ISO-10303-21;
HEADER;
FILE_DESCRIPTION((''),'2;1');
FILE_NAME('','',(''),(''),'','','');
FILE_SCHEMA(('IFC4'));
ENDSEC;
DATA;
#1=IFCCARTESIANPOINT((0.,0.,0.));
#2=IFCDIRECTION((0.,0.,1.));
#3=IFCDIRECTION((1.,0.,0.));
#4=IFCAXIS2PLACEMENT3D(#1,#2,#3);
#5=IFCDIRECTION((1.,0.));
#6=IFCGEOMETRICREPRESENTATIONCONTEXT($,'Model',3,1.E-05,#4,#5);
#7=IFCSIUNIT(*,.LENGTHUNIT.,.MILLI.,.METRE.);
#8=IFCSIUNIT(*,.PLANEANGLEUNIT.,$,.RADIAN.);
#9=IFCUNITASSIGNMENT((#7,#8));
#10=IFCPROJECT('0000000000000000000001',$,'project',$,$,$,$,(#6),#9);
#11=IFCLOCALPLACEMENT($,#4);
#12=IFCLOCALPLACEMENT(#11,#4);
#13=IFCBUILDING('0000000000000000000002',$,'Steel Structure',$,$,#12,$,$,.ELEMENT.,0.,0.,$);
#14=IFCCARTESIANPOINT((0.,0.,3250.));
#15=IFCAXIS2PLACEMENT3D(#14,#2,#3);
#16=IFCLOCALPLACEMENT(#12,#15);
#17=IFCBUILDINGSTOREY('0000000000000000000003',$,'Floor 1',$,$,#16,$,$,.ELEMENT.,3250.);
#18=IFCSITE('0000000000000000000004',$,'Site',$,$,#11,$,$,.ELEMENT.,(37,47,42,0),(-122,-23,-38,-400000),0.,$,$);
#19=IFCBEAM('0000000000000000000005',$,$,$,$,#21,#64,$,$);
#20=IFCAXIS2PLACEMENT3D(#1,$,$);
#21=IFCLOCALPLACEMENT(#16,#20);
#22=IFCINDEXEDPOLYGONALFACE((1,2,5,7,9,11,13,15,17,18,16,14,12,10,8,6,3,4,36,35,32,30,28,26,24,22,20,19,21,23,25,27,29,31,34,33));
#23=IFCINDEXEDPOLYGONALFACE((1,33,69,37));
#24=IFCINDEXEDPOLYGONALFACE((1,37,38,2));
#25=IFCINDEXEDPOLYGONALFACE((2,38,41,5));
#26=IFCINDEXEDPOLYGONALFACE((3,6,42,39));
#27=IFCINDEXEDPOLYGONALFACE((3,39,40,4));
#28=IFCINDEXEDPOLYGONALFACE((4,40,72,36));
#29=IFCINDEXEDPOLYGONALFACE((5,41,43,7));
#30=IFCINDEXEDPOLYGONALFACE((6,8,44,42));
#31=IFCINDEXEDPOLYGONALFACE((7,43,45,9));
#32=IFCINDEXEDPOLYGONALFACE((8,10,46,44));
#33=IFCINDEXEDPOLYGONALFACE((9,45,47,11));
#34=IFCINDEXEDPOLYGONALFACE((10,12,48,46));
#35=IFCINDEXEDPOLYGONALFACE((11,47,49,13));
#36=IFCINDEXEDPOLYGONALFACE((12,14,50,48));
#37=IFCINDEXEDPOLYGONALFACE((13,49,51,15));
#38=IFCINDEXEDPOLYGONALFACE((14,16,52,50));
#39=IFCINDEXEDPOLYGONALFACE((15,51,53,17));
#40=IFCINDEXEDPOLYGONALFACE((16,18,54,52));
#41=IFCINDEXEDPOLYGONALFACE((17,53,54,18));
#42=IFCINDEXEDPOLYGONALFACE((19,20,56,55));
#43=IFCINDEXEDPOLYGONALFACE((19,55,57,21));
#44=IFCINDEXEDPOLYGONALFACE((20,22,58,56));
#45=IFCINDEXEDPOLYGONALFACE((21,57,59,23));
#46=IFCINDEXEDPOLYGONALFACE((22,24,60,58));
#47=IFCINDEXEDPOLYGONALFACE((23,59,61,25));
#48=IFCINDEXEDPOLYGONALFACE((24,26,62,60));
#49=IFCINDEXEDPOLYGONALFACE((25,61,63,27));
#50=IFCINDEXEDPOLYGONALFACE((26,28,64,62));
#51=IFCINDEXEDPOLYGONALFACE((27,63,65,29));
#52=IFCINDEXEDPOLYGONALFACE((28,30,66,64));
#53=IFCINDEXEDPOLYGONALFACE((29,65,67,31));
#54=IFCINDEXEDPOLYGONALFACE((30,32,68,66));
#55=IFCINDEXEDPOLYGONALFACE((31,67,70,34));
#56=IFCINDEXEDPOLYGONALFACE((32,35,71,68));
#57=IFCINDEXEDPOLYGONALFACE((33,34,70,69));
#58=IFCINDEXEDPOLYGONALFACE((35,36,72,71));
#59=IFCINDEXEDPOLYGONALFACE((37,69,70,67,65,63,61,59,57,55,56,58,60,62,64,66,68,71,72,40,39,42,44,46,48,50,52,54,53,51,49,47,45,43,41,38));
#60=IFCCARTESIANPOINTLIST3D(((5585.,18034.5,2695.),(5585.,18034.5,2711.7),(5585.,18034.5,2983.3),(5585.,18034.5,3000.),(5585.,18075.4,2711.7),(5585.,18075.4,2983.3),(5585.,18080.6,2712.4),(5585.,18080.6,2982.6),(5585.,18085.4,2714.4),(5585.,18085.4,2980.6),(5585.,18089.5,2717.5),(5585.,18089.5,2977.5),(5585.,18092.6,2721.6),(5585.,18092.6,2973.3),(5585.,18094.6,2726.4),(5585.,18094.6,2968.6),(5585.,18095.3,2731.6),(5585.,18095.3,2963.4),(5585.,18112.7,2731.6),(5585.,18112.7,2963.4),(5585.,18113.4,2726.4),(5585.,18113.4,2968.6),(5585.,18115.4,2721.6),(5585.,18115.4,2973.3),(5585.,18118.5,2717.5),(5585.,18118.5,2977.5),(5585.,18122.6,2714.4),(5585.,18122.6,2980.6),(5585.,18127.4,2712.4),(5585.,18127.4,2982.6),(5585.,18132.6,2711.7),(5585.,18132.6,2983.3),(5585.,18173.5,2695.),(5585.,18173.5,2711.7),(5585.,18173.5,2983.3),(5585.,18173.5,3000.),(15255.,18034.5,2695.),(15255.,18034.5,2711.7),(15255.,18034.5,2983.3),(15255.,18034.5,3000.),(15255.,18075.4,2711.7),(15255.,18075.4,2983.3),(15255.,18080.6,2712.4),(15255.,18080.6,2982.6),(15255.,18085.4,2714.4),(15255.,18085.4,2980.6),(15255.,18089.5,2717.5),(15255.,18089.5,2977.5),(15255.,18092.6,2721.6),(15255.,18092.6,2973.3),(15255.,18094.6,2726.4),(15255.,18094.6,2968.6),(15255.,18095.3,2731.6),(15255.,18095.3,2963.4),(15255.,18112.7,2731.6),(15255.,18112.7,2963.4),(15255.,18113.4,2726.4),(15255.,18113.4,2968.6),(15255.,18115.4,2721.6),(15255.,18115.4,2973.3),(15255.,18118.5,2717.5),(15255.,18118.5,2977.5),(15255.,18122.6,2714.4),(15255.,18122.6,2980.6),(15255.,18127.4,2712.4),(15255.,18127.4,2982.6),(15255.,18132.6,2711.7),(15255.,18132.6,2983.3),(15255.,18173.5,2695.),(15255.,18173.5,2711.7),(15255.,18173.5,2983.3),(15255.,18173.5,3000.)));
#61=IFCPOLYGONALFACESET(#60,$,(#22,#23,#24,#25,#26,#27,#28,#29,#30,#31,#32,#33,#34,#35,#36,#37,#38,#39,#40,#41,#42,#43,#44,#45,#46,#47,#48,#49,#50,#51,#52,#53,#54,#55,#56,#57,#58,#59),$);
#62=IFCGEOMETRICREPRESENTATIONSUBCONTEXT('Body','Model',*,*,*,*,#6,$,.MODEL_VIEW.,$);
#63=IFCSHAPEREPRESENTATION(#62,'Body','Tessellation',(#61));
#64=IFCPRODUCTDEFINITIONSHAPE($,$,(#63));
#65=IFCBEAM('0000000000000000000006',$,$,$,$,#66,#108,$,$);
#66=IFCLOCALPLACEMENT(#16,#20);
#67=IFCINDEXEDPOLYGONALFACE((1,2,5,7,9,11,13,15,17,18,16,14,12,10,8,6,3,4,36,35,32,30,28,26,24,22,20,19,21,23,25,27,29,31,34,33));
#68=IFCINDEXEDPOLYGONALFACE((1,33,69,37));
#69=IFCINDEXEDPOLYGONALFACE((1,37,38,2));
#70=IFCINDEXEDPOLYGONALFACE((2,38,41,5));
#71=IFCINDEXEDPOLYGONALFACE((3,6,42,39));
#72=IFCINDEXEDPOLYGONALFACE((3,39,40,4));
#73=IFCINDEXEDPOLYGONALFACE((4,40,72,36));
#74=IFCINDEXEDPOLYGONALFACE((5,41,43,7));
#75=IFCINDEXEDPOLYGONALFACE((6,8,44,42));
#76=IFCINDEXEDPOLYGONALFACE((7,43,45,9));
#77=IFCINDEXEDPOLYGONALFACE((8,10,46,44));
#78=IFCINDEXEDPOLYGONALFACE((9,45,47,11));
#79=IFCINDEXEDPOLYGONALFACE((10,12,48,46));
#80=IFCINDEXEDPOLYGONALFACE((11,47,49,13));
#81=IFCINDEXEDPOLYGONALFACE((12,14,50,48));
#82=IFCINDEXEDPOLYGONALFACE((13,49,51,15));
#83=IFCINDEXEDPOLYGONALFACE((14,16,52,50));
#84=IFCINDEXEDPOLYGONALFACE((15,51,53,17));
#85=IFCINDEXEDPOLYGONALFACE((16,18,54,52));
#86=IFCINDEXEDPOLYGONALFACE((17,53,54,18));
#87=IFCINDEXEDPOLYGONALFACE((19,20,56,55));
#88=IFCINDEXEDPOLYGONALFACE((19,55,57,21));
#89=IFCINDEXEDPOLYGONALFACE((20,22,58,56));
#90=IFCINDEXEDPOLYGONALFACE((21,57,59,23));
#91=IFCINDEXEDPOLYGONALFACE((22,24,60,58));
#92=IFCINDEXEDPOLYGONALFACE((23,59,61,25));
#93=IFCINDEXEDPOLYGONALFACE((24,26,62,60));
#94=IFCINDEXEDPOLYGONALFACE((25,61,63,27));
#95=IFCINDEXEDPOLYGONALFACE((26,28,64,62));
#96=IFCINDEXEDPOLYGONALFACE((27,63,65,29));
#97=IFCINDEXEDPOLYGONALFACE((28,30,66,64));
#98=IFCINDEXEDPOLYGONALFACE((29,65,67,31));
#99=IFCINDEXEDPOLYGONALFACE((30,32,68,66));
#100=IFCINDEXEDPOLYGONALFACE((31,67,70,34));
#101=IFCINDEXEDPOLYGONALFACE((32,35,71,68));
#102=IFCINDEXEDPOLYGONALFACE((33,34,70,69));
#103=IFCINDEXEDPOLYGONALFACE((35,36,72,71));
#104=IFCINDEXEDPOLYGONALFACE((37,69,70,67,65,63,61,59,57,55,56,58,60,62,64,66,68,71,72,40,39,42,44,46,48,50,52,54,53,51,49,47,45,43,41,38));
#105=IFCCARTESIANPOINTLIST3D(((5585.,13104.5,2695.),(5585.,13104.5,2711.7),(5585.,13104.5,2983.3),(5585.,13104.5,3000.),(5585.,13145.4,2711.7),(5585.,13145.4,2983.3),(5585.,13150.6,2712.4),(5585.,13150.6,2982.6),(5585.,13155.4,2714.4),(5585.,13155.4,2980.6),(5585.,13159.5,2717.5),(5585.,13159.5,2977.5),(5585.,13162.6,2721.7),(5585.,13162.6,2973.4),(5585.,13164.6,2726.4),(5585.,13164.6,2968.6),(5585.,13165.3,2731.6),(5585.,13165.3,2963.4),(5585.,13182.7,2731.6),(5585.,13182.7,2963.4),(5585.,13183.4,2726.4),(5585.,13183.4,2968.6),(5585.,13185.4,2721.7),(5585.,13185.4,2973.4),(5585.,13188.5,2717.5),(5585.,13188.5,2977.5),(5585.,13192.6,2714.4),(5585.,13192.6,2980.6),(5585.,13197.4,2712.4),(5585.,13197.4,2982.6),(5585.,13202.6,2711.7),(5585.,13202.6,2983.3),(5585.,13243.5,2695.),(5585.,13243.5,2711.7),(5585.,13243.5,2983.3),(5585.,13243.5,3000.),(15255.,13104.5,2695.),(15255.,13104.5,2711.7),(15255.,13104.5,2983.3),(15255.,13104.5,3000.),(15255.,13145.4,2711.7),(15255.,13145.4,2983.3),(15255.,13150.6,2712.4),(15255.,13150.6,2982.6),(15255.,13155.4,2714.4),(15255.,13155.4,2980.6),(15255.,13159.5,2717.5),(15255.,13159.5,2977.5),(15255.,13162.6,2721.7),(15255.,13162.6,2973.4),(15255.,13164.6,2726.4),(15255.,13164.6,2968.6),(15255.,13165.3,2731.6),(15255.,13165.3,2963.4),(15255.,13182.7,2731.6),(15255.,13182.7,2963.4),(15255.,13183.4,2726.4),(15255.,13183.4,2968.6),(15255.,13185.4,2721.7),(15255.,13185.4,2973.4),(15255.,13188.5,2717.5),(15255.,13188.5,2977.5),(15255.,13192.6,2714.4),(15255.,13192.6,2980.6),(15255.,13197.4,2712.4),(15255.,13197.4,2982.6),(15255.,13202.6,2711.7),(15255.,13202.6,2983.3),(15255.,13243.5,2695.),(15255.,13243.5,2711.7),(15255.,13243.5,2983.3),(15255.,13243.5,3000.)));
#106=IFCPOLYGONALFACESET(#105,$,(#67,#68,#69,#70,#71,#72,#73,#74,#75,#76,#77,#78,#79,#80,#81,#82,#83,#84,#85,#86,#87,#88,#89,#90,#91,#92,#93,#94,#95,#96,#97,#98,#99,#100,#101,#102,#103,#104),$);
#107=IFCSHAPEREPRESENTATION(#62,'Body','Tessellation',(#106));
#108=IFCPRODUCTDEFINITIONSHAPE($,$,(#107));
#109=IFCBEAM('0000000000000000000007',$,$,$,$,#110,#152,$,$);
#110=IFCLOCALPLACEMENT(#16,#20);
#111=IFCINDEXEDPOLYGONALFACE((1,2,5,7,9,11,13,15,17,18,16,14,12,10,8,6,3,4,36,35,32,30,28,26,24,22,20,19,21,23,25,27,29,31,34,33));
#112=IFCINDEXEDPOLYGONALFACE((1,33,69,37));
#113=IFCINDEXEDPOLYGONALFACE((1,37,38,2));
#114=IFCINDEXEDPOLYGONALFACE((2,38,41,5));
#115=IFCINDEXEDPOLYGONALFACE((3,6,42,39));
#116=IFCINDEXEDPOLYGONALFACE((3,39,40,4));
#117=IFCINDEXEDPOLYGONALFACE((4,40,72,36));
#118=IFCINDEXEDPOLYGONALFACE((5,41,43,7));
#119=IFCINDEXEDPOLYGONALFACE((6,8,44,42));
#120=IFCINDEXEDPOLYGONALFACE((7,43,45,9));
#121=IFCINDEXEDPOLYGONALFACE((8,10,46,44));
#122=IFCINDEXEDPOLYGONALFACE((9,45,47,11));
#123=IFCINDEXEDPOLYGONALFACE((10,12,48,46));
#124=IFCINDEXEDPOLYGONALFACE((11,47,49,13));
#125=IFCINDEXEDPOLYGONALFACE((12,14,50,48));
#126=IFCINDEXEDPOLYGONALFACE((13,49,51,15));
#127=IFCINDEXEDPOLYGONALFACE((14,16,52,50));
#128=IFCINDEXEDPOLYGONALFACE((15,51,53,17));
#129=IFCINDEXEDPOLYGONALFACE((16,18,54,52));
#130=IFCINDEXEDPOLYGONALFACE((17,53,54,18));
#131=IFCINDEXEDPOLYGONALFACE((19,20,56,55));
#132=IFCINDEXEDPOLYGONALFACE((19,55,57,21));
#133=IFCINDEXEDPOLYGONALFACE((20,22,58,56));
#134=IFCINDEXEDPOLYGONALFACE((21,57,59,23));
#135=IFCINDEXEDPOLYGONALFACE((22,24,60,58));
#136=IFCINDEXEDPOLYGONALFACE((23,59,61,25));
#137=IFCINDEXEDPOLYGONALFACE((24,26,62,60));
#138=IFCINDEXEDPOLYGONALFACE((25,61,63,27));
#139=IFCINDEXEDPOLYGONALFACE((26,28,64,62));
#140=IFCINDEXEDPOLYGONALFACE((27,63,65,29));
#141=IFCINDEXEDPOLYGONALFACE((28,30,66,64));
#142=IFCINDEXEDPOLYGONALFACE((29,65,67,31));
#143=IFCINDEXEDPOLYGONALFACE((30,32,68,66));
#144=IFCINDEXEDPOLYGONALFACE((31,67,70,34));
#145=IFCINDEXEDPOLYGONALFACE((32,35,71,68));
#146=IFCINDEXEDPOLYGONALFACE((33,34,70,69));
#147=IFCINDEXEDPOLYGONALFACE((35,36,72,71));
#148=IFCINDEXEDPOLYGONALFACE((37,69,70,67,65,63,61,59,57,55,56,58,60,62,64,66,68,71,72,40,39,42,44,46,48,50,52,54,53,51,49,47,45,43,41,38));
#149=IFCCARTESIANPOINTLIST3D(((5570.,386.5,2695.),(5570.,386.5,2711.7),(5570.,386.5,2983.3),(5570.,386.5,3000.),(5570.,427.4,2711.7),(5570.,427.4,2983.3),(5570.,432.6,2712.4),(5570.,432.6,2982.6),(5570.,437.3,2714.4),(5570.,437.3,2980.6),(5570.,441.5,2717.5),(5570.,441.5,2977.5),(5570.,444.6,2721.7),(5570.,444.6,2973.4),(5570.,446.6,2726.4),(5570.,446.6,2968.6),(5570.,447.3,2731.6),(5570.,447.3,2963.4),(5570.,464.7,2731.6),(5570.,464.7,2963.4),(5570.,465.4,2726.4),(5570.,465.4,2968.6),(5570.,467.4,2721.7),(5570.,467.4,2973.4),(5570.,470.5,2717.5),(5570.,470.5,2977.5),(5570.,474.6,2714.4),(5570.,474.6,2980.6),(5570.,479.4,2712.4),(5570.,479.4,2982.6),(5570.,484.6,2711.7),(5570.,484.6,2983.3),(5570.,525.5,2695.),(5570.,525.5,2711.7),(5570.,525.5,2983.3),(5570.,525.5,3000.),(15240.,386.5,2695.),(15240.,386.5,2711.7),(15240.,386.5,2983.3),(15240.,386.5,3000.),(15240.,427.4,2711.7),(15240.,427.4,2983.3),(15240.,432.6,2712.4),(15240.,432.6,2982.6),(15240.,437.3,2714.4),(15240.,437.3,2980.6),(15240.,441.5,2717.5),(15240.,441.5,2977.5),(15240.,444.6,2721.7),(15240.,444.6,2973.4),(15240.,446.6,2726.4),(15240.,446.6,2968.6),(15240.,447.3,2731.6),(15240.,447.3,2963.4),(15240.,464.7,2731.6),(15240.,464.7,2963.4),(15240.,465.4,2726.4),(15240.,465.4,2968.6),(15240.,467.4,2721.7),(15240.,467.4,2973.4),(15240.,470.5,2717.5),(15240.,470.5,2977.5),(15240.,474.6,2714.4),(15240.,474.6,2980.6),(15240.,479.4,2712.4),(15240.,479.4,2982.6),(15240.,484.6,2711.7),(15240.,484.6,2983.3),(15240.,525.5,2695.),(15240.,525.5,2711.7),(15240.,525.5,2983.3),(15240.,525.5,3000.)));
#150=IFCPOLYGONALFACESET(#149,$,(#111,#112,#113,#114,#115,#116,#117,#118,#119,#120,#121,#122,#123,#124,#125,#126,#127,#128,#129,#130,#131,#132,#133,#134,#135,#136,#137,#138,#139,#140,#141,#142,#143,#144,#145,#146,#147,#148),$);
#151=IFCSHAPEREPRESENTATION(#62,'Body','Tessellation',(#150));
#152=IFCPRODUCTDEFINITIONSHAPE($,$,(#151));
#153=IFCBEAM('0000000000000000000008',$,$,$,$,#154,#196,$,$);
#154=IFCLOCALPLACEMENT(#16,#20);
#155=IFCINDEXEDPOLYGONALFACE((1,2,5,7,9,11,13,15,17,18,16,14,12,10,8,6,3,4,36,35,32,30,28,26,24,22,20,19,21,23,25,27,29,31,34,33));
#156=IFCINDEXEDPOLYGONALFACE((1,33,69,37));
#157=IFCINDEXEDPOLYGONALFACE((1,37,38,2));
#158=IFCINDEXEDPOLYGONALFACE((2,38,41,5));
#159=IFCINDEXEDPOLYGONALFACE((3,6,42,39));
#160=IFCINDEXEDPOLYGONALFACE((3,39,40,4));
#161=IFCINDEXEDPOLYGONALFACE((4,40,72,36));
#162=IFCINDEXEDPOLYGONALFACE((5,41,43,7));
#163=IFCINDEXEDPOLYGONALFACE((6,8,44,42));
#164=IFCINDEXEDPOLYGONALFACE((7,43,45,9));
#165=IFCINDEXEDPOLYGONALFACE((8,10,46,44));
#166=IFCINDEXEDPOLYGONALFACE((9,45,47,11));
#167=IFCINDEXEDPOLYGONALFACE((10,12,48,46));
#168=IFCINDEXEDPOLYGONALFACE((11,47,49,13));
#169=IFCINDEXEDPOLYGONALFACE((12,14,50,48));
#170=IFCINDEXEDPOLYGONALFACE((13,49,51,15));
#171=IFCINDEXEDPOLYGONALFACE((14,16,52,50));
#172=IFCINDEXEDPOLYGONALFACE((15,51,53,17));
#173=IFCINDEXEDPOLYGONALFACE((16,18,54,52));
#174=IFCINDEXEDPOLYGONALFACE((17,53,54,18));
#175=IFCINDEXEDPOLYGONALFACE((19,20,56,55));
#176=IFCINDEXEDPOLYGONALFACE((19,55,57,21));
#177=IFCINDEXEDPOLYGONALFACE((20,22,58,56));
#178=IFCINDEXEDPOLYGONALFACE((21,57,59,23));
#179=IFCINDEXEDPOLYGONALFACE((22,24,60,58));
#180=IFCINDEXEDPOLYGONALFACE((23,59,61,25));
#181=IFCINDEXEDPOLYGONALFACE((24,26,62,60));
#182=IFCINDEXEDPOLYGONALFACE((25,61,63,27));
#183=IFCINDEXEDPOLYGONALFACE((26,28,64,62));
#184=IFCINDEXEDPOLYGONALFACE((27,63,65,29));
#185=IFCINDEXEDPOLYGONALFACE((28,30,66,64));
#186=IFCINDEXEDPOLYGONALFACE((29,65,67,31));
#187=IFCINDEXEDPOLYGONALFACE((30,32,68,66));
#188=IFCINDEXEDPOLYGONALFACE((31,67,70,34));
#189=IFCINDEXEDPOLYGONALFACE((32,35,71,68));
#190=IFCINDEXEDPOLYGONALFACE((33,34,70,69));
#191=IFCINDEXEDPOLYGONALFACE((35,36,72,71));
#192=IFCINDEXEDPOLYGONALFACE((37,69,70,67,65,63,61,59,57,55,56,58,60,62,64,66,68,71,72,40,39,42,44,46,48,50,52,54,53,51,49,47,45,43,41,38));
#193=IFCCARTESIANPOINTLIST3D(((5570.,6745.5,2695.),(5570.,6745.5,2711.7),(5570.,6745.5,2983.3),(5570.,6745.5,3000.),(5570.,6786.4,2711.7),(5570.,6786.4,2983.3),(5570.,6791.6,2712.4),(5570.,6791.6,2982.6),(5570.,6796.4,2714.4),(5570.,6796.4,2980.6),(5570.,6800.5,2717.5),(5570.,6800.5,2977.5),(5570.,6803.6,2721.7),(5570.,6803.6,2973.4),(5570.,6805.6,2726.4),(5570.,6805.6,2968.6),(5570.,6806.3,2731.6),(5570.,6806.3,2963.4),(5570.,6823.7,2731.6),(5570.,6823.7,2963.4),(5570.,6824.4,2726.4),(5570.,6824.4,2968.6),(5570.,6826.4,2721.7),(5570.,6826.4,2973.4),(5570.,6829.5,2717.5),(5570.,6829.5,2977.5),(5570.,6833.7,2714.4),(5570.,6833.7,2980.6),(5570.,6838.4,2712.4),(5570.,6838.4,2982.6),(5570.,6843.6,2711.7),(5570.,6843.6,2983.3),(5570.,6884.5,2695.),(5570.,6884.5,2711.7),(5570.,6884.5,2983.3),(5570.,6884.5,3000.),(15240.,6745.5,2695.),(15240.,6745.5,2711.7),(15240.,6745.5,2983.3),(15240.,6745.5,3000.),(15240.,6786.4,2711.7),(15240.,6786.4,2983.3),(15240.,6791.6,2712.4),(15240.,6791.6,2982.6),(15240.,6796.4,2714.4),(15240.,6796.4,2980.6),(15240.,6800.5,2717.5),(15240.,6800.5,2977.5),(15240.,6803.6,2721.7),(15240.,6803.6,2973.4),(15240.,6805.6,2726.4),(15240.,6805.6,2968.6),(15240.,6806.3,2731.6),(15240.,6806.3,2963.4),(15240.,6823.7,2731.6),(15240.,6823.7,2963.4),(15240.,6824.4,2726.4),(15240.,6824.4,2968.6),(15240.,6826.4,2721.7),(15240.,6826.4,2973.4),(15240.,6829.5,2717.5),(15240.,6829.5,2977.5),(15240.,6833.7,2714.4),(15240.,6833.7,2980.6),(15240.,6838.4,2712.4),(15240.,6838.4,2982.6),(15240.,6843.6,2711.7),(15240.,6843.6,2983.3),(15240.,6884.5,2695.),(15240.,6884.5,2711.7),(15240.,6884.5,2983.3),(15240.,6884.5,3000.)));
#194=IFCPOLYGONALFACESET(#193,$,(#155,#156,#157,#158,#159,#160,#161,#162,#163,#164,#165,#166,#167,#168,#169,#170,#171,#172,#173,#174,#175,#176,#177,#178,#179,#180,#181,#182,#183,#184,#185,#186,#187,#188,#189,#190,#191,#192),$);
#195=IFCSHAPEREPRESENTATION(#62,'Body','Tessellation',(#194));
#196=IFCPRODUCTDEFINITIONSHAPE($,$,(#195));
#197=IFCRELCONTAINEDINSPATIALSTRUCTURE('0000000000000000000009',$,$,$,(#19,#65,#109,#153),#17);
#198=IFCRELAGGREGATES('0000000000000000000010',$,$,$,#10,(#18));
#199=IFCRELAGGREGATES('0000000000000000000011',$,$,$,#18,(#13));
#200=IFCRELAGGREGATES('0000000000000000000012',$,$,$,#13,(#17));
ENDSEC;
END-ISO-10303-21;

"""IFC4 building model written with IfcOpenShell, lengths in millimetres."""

from ifc_helpers import new_model, si_unit, direction, frame, origin_with_axes, origin_2d_with_axis, place, context, subcontext, project, spatial, i_section, extrude, element, save


model = new_model("IFC4")

# Units and contexts
model_context = context("Model", 3, precision=1e-05, world=origin_with_axes(), true_north=direction((1.0, 0.0)))
body_context = subcontext(model_context, "Body", "Model", "MODEL_VIEW")
ifc_project = project(units=[si_unit("LENGTHUNIT", "METRE", prefix="MILLI"), si_unit("PLANEANGLEUNIT", "RADIAN")], contexts=[model_context])

# Site, building, storey
site_placement = place(None, origin_with_axes())
site = spatial("IfcSite", under=ifc_project, at=site_placement, Name="Site", CompositionType="ELEMENT", RefLatitude=(37, 47, 42, 0), RefLongitude=(-122, -23, -38, -400000), RefElevation=0.0)
building_placement = place(site_placement, origin_with_axes())
building = spatial("IfcBuilding", under=site, at=building_placement, Name="Steel Structure", CompositionType="ELEMENT", ElevationOfRefHeight=0.0, ElevationOfTerrain=0.0)
storey_placement = place(building_placement, frame((0.0, 0.0, 3250.0), z_axis=(0.0, 0.0, 1.0), x_axis=(1.0, 0.0, 0.0)))
storey = spatial("IfcBuildingStorey", under=building, at=storey_placement, Name="Floor 1", CompositionType="ELEMENT", Elevation=3250.0)

# Beams
for number, where, z_axis, x_axis in (
    (1, (15255.0, 18104.0, 2695.0), (-1.0, 0.0, 0.0), (0.0, -1.0, 0.0)),
    (2, (5585.0, 13174.0, 2695.0), (1.0, 0.0, 0.0), (0.0, 1.0, 0.0)),
):
    element("IfcBeam", number, at=place(storey_placement, frame(where, z_axis=z_axis, x_axis=x_axis)), inside=storey, context=body_context, shape_type="SweptSolid", body=[
        extrude(i_section(OverallWidth=139.0, OverallDepth=305.0, WebThickness=17.4, FlangeThickness=16.7, FilletRadius=19.9, at=origin_2d_with_axis()), frame((0.0, 152.5, 0.0), z_axis=(0.0, 0.0, 1.0), x_axis=(1.0, 0.0, 0.0)), (0.0, 0.0, 1.0), 9670.0),
    ])
for number, where, z_axis, x_axis in (
    (3, (15240.0, 456.0, 2695.0), (-1.0, 0.0, 0.0), (0.0, -1.0, 0.0)),
    (4, (15240.0, 6815.0, 2695.0), (-1.0, 0.0, 0.0), (0.0, -1.0, 0.0)),
):
    element("IfcBeam", number, at=place(storey_placement, frame(where, z_axis=z_axis, x_axis=x_axis)), inside=storey, context=body_context, shape_type="SweptSolid", body=[
        extrude(i_section(OverallWidth=139.0, OverallDepth=305.0, WebThickness=17.4, FlangeThickness=16.7, FilletRadius=19.9, at=origin_2d_with_axis()), frame((0.0, 152.5, 0.0), z_axis=(0.0, 0.0, 1.0), x_axis=(1.0, 0.0, 0.0)), (0.0, 0.0, 1.0), 9670.0),
    ])

save(model, "model.ifc")
